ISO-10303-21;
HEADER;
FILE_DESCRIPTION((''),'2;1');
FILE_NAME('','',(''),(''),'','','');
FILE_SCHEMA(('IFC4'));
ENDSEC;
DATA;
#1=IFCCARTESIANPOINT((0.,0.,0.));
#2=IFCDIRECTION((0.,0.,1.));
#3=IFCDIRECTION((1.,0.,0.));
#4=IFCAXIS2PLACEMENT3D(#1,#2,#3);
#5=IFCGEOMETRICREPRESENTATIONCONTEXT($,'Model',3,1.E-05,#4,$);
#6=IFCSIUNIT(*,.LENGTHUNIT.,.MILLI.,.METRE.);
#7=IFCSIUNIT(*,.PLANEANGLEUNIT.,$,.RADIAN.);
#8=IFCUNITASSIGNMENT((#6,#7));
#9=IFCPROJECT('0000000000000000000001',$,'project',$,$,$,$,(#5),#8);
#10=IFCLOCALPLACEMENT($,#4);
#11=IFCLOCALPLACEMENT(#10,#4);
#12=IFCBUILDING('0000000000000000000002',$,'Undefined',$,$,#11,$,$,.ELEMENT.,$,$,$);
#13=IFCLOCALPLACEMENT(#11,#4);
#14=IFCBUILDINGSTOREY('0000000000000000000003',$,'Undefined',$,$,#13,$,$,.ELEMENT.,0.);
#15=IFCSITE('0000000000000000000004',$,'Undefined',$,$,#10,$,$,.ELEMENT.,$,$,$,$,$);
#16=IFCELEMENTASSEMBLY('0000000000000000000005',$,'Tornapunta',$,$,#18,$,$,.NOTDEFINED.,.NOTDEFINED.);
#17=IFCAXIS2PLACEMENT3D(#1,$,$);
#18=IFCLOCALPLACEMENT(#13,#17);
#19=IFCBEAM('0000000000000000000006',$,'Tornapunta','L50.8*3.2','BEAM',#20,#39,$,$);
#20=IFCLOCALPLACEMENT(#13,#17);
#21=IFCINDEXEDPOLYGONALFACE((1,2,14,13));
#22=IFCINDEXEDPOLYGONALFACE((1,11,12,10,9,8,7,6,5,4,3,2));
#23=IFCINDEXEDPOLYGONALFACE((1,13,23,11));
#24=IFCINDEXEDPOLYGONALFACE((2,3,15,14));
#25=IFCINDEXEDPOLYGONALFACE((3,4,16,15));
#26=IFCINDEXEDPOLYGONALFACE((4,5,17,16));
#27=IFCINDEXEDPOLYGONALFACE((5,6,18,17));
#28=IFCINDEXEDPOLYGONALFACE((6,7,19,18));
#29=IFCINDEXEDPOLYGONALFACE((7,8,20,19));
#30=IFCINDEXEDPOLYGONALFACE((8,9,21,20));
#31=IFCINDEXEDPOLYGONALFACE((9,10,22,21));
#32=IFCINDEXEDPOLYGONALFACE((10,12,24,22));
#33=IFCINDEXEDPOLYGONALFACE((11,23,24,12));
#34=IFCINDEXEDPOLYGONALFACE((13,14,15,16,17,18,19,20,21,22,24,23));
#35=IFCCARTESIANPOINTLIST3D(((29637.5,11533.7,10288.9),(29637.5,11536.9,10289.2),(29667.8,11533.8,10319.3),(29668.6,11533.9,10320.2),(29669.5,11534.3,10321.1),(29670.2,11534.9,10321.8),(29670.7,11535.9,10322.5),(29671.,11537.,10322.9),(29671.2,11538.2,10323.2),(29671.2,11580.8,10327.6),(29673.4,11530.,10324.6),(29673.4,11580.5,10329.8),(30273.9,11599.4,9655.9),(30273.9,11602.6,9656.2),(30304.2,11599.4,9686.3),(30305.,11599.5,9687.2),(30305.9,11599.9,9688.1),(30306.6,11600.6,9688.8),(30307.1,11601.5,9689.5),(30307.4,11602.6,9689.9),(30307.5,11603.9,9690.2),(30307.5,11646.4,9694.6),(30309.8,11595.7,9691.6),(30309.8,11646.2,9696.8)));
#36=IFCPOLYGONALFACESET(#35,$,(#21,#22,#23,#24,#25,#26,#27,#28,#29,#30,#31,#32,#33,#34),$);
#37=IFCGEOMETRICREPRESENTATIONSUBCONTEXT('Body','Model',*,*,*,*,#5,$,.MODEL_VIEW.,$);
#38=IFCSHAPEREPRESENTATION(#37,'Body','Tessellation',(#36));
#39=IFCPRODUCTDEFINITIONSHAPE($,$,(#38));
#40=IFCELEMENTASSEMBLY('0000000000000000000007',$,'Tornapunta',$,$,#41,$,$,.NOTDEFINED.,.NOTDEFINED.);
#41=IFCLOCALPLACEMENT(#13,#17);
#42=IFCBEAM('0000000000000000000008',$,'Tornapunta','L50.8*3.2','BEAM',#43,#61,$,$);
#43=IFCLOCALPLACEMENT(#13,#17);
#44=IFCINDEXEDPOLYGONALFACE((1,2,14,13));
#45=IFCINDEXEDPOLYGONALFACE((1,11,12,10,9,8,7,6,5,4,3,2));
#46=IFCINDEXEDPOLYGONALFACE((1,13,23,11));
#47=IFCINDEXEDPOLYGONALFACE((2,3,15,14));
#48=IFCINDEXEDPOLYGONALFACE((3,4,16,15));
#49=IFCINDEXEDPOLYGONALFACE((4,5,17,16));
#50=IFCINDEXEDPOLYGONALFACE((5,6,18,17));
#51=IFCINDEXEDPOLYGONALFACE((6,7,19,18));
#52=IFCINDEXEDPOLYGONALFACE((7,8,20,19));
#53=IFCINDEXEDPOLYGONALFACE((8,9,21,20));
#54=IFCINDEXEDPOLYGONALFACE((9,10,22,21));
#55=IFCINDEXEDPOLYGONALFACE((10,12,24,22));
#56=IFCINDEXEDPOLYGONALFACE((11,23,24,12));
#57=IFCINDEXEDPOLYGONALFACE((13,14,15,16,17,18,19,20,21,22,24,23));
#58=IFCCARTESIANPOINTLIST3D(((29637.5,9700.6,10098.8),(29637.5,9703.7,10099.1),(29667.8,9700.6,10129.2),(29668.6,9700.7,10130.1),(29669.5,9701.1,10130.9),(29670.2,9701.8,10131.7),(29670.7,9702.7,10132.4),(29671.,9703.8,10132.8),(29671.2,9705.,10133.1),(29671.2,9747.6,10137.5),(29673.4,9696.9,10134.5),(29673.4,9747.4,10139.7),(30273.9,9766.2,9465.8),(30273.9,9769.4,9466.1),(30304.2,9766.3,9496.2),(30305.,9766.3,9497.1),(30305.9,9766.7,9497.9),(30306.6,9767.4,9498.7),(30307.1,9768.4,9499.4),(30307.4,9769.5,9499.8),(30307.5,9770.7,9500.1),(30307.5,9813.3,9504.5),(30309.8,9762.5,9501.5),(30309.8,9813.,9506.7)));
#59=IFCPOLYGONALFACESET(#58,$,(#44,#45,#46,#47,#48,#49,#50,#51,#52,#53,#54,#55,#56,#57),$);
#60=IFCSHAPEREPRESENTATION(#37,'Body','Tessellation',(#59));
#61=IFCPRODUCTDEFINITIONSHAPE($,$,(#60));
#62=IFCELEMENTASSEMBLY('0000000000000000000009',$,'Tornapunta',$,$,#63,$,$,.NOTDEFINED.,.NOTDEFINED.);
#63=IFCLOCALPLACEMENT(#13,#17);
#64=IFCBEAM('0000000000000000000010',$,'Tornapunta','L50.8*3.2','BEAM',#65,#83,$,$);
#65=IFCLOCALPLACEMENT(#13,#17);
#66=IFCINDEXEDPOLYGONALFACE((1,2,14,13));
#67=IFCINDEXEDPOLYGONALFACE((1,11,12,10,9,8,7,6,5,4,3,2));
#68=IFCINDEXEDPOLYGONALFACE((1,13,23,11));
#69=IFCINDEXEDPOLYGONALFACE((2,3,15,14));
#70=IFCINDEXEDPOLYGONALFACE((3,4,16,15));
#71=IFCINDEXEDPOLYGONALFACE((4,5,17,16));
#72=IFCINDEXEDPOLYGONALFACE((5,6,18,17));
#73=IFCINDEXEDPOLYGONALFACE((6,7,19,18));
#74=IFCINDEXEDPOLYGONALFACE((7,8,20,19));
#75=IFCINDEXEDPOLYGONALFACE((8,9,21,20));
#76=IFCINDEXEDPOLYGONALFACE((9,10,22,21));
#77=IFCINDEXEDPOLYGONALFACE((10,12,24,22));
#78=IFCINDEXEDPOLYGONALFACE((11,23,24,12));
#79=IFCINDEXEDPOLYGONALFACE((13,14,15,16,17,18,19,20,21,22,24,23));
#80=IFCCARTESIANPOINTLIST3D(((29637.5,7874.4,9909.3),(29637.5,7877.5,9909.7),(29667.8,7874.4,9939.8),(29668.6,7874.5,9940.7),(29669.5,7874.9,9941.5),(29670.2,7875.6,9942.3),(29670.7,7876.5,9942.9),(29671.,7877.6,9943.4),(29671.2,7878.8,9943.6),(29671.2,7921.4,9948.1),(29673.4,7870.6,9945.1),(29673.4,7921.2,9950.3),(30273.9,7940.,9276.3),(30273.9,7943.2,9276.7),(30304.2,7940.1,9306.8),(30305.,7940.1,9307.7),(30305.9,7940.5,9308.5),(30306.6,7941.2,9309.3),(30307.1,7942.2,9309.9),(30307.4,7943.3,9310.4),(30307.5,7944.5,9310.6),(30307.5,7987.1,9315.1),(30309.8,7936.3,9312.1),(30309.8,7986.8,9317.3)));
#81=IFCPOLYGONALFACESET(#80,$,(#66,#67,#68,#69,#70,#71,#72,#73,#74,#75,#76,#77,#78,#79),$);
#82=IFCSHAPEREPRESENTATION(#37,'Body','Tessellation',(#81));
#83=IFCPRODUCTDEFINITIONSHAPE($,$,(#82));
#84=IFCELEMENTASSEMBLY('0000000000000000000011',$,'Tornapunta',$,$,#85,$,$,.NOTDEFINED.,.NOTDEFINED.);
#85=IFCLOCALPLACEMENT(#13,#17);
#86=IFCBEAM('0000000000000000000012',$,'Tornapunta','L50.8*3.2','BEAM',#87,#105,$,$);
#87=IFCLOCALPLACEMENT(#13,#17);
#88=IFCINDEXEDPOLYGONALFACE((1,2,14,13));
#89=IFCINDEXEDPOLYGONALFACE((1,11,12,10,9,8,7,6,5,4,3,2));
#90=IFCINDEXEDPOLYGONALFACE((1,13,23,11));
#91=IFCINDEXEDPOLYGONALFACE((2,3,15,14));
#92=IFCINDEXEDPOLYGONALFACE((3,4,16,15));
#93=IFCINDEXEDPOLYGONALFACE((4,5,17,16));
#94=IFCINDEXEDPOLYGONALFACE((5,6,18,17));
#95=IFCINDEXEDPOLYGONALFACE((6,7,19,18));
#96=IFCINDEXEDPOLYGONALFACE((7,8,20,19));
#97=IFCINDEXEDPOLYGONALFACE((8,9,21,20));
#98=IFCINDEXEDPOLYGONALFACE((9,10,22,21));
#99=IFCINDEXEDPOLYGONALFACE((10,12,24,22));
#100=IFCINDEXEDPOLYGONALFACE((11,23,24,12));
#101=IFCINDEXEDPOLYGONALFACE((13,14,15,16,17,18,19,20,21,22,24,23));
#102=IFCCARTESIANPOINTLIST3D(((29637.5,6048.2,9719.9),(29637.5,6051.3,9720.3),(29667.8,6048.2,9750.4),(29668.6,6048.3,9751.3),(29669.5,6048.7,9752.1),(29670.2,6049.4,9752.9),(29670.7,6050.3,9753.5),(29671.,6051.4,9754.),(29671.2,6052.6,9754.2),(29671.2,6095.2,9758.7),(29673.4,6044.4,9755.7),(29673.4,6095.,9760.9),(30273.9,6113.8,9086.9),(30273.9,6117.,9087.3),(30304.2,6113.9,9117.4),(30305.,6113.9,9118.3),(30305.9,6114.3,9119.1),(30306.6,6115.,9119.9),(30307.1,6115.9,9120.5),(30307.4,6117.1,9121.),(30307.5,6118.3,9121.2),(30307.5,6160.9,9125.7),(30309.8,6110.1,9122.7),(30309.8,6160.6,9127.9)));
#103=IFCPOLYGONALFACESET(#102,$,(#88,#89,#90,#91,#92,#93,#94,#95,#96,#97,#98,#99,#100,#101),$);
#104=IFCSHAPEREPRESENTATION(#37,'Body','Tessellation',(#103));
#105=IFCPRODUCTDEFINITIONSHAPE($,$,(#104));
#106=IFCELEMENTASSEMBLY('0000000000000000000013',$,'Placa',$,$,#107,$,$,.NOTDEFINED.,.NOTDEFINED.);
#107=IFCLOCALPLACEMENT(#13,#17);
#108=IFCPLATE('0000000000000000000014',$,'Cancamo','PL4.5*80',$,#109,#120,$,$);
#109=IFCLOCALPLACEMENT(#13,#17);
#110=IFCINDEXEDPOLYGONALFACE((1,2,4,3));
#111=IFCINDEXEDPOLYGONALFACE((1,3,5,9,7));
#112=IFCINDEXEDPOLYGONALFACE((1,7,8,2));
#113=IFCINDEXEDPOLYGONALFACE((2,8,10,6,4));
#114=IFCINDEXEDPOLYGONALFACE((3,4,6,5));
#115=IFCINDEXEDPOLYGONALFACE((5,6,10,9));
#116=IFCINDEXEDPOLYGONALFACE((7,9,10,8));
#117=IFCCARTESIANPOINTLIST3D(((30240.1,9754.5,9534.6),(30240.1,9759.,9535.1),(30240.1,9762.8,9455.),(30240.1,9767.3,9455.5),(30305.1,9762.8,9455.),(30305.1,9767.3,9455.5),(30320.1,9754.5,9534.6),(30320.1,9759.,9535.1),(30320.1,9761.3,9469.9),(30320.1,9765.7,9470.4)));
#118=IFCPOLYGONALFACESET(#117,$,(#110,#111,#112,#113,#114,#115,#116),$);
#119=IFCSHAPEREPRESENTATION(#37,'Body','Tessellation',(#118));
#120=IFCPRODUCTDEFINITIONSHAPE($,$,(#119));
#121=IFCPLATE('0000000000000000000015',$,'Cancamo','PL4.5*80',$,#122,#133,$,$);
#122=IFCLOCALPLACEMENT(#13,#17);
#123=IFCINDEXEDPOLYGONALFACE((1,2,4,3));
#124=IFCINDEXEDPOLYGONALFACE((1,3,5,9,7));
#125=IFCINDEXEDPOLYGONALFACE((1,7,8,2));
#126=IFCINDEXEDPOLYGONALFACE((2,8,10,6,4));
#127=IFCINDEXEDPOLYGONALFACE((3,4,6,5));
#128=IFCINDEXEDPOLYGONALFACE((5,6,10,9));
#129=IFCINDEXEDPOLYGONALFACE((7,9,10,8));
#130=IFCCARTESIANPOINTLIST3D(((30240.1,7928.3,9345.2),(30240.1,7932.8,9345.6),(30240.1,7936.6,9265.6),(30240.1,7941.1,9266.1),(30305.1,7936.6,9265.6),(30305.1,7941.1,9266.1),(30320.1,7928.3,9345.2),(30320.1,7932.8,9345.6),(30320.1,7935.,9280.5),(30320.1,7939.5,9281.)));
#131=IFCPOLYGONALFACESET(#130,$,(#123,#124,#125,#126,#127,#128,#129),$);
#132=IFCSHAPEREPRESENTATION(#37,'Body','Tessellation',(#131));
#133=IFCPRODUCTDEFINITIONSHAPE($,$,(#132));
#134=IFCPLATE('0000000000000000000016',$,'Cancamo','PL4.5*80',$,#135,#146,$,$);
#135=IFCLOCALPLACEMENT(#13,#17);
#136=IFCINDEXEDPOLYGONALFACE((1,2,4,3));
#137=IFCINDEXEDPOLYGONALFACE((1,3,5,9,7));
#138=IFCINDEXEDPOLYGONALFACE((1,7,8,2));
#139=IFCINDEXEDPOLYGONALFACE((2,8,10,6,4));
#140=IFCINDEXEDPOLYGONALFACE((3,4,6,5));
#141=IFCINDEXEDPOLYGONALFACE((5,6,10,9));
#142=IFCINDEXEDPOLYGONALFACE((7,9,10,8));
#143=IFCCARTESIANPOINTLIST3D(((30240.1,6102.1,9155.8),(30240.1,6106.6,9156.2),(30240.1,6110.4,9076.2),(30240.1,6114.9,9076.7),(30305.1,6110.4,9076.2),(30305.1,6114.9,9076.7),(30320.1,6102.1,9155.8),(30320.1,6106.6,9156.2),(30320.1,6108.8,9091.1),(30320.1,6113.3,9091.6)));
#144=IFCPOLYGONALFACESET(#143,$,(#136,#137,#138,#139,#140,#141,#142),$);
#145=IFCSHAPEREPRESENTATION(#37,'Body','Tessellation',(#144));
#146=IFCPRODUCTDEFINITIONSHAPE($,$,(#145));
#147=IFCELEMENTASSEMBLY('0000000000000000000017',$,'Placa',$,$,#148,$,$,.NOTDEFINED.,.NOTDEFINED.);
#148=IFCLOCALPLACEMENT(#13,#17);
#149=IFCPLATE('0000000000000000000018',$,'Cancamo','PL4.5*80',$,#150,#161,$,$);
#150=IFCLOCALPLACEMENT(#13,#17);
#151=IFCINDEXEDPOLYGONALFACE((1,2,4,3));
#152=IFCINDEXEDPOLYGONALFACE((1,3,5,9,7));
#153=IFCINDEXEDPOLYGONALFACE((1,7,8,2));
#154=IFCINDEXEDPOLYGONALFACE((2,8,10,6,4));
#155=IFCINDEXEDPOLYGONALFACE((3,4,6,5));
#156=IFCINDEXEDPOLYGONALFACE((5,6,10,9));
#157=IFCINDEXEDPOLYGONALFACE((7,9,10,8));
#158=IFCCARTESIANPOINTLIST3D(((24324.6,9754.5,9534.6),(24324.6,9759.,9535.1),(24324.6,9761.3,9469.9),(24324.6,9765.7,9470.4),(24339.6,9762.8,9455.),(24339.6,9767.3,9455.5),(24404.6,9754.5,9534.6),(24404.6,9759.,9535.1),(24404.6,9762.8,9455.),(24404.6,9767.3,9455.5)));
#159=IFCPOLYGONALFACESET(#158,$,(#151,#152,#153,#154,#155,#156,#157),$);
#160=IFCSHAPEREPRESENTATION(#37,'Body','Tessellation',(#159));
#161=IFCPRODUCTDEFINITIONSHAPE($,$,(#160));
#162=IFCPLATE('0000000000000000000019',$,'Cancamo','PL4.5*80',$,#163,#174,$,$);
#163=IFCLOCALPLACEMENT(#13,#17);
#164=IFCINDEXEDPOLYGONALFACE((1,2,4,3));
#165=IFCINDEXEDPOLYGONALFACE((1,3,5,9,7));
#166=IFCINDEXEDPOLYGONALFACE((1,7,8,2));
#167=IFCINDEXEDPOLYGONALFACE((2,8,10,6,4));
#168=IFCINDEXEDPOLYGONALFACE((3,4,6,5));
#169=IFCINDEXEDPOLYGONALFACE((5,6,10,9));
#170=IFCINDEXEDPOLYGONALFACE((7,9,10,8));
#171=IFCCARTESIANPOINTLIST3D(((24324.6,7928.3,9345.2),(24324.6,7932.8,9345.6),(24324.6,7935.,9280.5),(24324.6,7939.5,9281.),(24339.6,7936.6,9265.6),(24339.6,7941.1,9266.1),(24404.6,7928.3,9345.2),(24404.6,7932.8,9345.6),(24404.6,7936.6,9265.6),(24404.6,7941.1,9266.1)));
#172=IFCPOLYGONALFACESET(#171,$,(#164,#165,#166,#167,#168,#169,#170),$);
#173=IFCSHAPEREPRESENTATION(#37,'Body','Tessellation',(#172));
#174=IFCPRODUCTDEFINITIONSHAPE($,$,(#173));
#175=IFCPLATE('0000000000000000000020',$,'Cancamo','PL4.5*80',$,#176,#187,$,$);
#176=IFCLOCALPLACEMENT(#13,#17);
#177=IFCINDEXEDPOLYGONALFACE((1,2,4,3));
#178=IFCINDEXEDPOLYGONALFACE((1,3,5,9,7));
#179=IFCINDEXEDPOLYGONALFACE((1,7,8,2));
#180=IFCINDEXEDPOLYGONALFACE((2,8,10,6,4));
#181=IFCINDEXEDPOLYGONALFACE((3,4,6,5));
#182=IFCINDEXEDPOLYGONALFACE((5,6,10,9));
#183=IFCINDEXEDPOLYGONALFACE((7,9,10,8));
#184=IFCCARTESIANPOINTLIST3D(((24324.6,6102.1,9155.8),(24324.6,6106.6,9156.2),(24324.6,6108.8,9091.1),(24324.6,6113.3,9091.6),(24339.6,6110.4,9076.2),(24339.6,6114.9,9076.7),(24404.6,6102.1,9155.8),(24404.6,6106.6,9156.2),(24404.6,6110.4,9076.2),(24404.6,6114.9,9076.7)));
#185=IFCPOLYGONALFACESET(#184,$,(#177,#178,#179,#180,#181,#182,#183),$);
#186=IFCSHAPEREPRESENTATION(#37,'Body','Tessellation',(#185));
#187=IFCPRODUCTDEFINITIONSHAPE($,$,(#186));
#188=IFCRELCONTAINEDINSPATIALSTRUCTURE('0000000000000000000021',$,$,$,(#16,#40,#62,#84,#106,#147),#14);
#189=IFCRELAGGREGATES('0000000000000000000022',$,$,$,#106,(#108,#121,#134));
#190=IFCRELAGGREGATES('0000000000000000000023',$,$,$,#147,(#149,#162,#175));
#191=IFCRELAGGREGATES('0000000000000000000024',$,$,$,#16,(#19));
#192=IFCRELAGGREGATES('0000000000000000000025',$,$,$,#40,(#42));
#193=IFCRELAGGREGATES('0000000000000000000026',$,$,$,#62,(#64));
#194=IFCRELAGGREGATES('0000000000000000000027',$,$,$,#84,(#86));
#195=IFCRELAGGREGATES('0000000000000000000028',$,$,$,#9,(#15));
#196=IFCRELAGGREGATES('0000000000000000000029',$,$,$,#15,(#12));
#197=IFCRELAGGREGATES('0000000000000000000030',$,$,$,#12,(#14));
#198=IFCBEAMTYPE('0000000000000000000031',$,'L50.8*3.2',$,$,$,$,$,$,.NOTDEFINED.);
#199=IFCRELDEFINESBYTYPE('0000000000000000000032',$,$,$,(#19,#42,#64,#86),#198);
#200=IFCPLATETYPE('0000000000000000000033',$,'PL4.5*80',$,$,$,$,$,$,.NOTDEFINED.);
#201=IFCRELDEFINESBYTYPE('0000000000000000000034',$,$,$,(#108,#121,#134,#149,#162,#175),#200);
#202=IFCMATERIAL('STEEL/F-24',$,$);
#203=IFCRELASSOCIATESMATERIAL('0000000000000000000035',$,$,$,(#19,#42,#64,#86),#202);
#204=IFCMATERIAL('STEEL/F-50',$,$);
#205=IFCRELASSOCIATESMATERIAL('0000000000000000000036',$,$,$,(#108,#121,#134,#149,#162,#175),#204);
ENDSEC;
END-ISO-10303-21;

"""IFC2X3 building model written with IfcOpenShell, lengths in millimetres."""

from ifc_helpers import new_model, si_unit, frame, origin_with_axes, origin_2d_with_axis, place, context, subcontext, project, spatial, polyline, l_section, outline, extrude, material, type_object, element, aggregate, save


model = new_model("IFC2X3")

# Units and contexts
model_context = context("Model", 3, precision=1e-05, world=origin_with_axes())
body_context = subcontext(model_context, "Body", "Model", "MODEL_VIEW")
ifc_project = project(units=[si_unit("LENGTHUNIT", "METRE", prefix="MILLI"), si_unit("PLANEANGLEUNIT", "RADIAN")], contexts=[model_context])

# Site, building, storey
site_placement = place(None, origin_with_axes())
site = spatial("IfcSite", under=ifc_project, at=site_placement, Name="Undefined", CompositionType="ELEMENT")
building_placement = place(site_placement, origin_with_axes())
building = spatial("IfcBuilding", under=site, at=building_placement, Name="Undefined", CompositionType="ELEMENT")
storey_placement = place(building_placement, origin_with_axes())
storey = spatial("IfcBuildingStorey", under=building, at=storey_placement, Name="Undefined", CompositionType="ELEMENT", Elevation=0.0)

# Element assemblies, beams
assembly_1_placement = place(storey_placement, origin_with_axes())
assembly_1 = element("IfcElementAssembly", 1, at=assembly_1_placement, inside=storey, Name="Tornapunta", AssemblyPlace="NOTDEFINED", PredefinedType="NOTDEFINED")
ifc_material_1 = material(Name="STEEL/F-24")
beam_type_1 = type_object("IfcBeamType", Name="L50.8*3.2", PredefinedType="NOTDEFINED")
beam_1_placement = place(assembly_1_placement, frame((29655.5, 11557.1, 10309.4), z_axis=(-0.707107, 0.072947, -0.703334), x_axis=(0.707107, 0.072947, -0.703334)))
beam_1 = element("IfcBeam", 2, at=beam_1_placement, type_object=beam_type_1, material=ifc_material_1, Name="Tornapunta", Description="L50.8*3.2", ObjectType="BEAM", context=body_context, shape_type="SweptSolid", body=[
    extrude(l_section(Depth=50.8, Width=50.8, Thickness=3.2, FilletRadius=4.8, at=origin_2d_with_axis()), frame((900.0, 0.0, 0.0), z_axis=(-1.0, 0.0, 0.0), x_axis=(0.0, -1.0, 0.0)), (0.0, 0.0, 1.0), 900.0),
])
assembly_2_placement = place(storey_placement, origin_with_axes())
assembly_2 = element("IfcElementAssembly", 3, at=assembly_2_placement, inside=storey, Name="Tornapunta", AssemblyPlace="NOTDEFINED", PredefinedType="NOTDEFINED")
beam_2_placement = place(assembly_2_placement, frame((29655.5, 9724.0, 10119.2), z_axis=(-0.707107, 0.072947, -0.703334), x_axis=(0.707107, 0.072947, -0.703334)))
beam_2 = element("IfcBeam", 4, at=beam_2_placement, type_object=beam_type_1, material=ifc_material_1, Name="Tornapunta", Description="L50.8*3.2", ObjectType="BEAM", context=body_context, shape_type="SweptSolid", body=[
    extrude(l_section(Depth=50.8, Width=50.8, Thickness=3.2, FilletRadius=4.8, at=origin_2d_with_axis()), frame((900.0, 0.0, 0.0), z_axis=(-1.0, 0.0, 0.0), x_axis=(0.0, -1.0, 0.0)), (0.0, 0.0, 1.0), 900.0),
])
assembly_3_placement = place(storey_placement, origin_with_axes())
assembly_3 = element("IfcElementAssembly", 5, at=assembly_3_placement, inside=storey, Name="Tornapunta", AssemblyPlace="NOTDEFINED", PredefinedType="NOTDEFINED")
beam_3_placement = place(assembly_3_placement, frame((29655.5, 7897.8, 9929.8), z_axis=(-0.707107, 0.072947, -0.703334), x_axis=(0.707107, 0.072947, -0.703334)))
beam_3 = element("IfcBeam", 6, at=beam_3_placement, type_object=beam_type_1, material=ifc_material_1, Name="Tornapunta", Description="L50.8*3.2", ObjectType="BEAM", context=body_context, shape_type="SweptSolid", body=[
    extrude(l_section(Depth=50.8, Width=50.8, Thickness=3.2, FilletRadius=4.8, at=origin_2d_with_axis()), frame((900.0, 0.0, 0.0), z_axis=(-1.0, 0.0, 0.0), x_axis=(0.0, -1.0, 0.0)), (0.0, 0.0, 1.0), 900.0),
])
assembly_4_placement = place(storey_placement, origin_with_axes())
assembly_4 = element("IfcElementAssembly", 7, at=assembly_4_placement, inside=storey, Name="Tornapunta", AssemblyPlace="NOTDEFINED", PredefinedType="NOTDEFINED")
beam_4_placement = place(assembly_4_placement, frame((29655.5, 6071.6, 9740.4), z_axis=(-0.707107, 0.072947, -0.703334), x_axis=(0.707107, 0.072947, -0.703334)))
beam_4 = element("IfcBeam", 8, at=beam_4_placement, type_object=beam_type_1, material=ifc_material_1, Name="Tornapunta", Description="L50.8*3.2", ObjectType="BEAM", context=body_context, shape_type="SweptSolid", body=[
    extrude(l_section(Depth=50.8, Width=50.8, Thickness=3.2, FilletRadius=4.8, at=origin_2d_with_axis()), frame((900.0, 0.0, 0.0), z_axis=(-1.0, 0.0, 0.0), x_axis=(0.0, -1.0, 0.0)), (0.0, 0.0, 1.0), 900.0),
])

# Element assemblies, plates
assembly_5_placement = place(storey_placement, origin_with_axes())
assembly_5 = element("IfcElementAssembly", 9, at=assembly_5_placement, inside=storey, Name="Placa", AssemblyPlace="NOTDEFINED", PredefinedType="NOTDEFINED")
ifc_material_2 = material(Name="STEEL/F-50")
plate_type = type_object("IfcPlateType", Name="PL4.5*80", PredefinedType="NOTDEFINED")
plate_1_placement = place(assembly_5_placement, frame((30240.1, 9765.0, 9455.3), z_axis=(0.0, -0.994665, -0.103162), x_axis=(1.0, 0.0, 0.0)))
plate_1 = element("IfcPlate", 10, at=plate_1_placement, type_object=plate_type, material=ifc_material_2, Name="Cancamo", Description="PL4.5*80", context=body_context, shape_type="SweptSolid", body=[
    extrude(outline(polyline([(0.0, 0.0), (65.0, 0.0), (80.0, 15.0), (80.0, 80.0), (0.0, 80.0), (0.0, 0.0)])), frame((0.0, 0.0, -2.2), z_axis=(0.0, 0.0, 1.0), x_axis=(1.0, 0.0, 0.0)), (0.0, 0.0, 1.0), 4.5),
])
plate_2_placement = place(assembly_5_placement, frame((30240.1, 7938.8, 9265.8), z_axis=(0.0, -0.994665, -0.103162), x_axis=(1.0, 0.0, 0.0)))
plate_2 = element("IfcPlate", 11, at=plate_2_placement, type_object=plate_type, material=ifc_material_2, Name="Cancamo", Description="PL4.5*80", context=body_context, shape_type="SweptSolid", body=[
    extrude(outline(polyline([(0.0, 0.0), (65.0, 0.0), (80.0, 15.0), (80.0, 80.0), (0.0, 80.0), (0.0, 0.0)])), frame((0.0, 0.0, -2.2), z_axis=(0.0, 0.0, 1.0), x_axis=(1.0, 0.0, 0.0)), (0.0, 0.0, 1.0), 4.5),
])
plate_3_placement = place(assembly_5_placement, frame((30240.1, 6112.6, 9076.4), z_axis=(0.0, -0.994665, -0.103162), x_axis=(1.0, 0.0, 0.0)))
plate_3 = element("IfcPlate", 12, at=plate_3_placement, type_object=plate_type, material=ifc_material_2, Name="Cancamo", Description="PL4.5*80", context=body_context, shape_type="SweptSolid", body=[
    extrude(outline(polyline([(0.0, 0.0), (65.0, 0.0), (80.0, 15.0), (80.0, 80.0), (0.0, 80.0), (0.0, 0.0)])), frame((0.0, 0.0, -2.2), z_axis=(0.0, 0.0, 1.0), x_axis=(1.0, 0.0, 0.0)), (0.0, 0.0, 1.0), 4.5),
])
aggregate(assembly_5, [plate_1, plate_2, plate_3])
assembly_6_placement = place(storey_placement, origin_with_axes())
assembly_6 = element("IfcElementAssembly", 13, at=assembly_6_placement, inside=storey, Name="Placa", AssemblyPlace="NOTDEFINED", PredefinedType="NOTDEFINED")
plate_4_placement = place(assembly_6_placement, frame((24404.6, 9765.0, 9455.3), z_axis=(0.0, 0.994665, 0.103162), x_axis=(-1.0, 0.0, 0.0)))
plate_4 = element("IfcPlate", 14, at=plate_4_placement, type_object=plate_type, material=ifc_material_2, Name="Cancamo", Description="PL4.5*80", context=body_context, shape_type="SweptSolid", body=[
    extrude(outline(polyline([(0.0, 0.0), (65.0, 0.0), (80.0, 15.0), (80.0, 80.0), (0.0, 80.0), (0.0, 0.0)])), frame((0.0, 0.0, -2.2), z_axis=(0.0, 0.0, 1.0), x_axis=(1.0, 0.0, 0.0)), (0.0, 0.0, 1.0), 4.5),
])
plate_5_placement = place(assembly_6_placement, frame((24404.6, 7938.8, 9265.8), z_axis=(0.0, 0.994665, 0.103162), x_axis=(-1.0, 0.0, 0.0)))
plate_5 = element("IfcPlate", 15, at=plate_5_placement, type_object=plate_type, material=ifc_material_2, Name="Cancamo", Description="PL4.5*80", context=body_context, shape_type="SweptSolid", body=[
    extrude(outline(polyline([(0.0, 0.0), (65.0, 0.0), (80.0, 15.0), (80.0, 80.0), (0.0, 80.0), (0.0, 0.0)])), frame((0.0, 0.0, -2.2), z_axis=(0.0, 0.0, 1.0), x_axis=(1.0, 0.0, 0.0)), (0.0, 0.0, 1.0), 4.5),
])
plate_6_placement = place(assembly_6_placement, frame((24404.6, 6112.6, 9076.4), z_axis=(0.0, 0.994665, 0.103162), x_axis=(-1.0, 0.0, 0.0)))
plate_6 = element("IfcPlate", 16, at=plate_6_placement, type_object=plate_type, material=ifc_material_2, Name="Cancamo", Description="PL4.5*80", context=body_context, shape_type="SweptSolid", body=[
    extrude(outline(polyline([(0.0, 0.0), (65.0, 0.0), (80.0, 15.0), (80.0, 80.0), (0.0, 80.0), (0.0, 0.0)])), frame((0.0, 0.0, -2.2), z_axis=(0.0, 0.0, 1.0), x_axis=(1.0, 0.0, 0.0)), (0.0, 0.0, 1.0), 4.5),
])
aggregate(assembly_6, [plate_4, plate_5, plate_6])

aggregate(assembly_1, [beam_1])
aggregate(assembly_2, [beam_2])
aggregate(assembly_3, [beam_3])
aggregate(assembly_4, [beam_4])

save(model, "model.ifc")
